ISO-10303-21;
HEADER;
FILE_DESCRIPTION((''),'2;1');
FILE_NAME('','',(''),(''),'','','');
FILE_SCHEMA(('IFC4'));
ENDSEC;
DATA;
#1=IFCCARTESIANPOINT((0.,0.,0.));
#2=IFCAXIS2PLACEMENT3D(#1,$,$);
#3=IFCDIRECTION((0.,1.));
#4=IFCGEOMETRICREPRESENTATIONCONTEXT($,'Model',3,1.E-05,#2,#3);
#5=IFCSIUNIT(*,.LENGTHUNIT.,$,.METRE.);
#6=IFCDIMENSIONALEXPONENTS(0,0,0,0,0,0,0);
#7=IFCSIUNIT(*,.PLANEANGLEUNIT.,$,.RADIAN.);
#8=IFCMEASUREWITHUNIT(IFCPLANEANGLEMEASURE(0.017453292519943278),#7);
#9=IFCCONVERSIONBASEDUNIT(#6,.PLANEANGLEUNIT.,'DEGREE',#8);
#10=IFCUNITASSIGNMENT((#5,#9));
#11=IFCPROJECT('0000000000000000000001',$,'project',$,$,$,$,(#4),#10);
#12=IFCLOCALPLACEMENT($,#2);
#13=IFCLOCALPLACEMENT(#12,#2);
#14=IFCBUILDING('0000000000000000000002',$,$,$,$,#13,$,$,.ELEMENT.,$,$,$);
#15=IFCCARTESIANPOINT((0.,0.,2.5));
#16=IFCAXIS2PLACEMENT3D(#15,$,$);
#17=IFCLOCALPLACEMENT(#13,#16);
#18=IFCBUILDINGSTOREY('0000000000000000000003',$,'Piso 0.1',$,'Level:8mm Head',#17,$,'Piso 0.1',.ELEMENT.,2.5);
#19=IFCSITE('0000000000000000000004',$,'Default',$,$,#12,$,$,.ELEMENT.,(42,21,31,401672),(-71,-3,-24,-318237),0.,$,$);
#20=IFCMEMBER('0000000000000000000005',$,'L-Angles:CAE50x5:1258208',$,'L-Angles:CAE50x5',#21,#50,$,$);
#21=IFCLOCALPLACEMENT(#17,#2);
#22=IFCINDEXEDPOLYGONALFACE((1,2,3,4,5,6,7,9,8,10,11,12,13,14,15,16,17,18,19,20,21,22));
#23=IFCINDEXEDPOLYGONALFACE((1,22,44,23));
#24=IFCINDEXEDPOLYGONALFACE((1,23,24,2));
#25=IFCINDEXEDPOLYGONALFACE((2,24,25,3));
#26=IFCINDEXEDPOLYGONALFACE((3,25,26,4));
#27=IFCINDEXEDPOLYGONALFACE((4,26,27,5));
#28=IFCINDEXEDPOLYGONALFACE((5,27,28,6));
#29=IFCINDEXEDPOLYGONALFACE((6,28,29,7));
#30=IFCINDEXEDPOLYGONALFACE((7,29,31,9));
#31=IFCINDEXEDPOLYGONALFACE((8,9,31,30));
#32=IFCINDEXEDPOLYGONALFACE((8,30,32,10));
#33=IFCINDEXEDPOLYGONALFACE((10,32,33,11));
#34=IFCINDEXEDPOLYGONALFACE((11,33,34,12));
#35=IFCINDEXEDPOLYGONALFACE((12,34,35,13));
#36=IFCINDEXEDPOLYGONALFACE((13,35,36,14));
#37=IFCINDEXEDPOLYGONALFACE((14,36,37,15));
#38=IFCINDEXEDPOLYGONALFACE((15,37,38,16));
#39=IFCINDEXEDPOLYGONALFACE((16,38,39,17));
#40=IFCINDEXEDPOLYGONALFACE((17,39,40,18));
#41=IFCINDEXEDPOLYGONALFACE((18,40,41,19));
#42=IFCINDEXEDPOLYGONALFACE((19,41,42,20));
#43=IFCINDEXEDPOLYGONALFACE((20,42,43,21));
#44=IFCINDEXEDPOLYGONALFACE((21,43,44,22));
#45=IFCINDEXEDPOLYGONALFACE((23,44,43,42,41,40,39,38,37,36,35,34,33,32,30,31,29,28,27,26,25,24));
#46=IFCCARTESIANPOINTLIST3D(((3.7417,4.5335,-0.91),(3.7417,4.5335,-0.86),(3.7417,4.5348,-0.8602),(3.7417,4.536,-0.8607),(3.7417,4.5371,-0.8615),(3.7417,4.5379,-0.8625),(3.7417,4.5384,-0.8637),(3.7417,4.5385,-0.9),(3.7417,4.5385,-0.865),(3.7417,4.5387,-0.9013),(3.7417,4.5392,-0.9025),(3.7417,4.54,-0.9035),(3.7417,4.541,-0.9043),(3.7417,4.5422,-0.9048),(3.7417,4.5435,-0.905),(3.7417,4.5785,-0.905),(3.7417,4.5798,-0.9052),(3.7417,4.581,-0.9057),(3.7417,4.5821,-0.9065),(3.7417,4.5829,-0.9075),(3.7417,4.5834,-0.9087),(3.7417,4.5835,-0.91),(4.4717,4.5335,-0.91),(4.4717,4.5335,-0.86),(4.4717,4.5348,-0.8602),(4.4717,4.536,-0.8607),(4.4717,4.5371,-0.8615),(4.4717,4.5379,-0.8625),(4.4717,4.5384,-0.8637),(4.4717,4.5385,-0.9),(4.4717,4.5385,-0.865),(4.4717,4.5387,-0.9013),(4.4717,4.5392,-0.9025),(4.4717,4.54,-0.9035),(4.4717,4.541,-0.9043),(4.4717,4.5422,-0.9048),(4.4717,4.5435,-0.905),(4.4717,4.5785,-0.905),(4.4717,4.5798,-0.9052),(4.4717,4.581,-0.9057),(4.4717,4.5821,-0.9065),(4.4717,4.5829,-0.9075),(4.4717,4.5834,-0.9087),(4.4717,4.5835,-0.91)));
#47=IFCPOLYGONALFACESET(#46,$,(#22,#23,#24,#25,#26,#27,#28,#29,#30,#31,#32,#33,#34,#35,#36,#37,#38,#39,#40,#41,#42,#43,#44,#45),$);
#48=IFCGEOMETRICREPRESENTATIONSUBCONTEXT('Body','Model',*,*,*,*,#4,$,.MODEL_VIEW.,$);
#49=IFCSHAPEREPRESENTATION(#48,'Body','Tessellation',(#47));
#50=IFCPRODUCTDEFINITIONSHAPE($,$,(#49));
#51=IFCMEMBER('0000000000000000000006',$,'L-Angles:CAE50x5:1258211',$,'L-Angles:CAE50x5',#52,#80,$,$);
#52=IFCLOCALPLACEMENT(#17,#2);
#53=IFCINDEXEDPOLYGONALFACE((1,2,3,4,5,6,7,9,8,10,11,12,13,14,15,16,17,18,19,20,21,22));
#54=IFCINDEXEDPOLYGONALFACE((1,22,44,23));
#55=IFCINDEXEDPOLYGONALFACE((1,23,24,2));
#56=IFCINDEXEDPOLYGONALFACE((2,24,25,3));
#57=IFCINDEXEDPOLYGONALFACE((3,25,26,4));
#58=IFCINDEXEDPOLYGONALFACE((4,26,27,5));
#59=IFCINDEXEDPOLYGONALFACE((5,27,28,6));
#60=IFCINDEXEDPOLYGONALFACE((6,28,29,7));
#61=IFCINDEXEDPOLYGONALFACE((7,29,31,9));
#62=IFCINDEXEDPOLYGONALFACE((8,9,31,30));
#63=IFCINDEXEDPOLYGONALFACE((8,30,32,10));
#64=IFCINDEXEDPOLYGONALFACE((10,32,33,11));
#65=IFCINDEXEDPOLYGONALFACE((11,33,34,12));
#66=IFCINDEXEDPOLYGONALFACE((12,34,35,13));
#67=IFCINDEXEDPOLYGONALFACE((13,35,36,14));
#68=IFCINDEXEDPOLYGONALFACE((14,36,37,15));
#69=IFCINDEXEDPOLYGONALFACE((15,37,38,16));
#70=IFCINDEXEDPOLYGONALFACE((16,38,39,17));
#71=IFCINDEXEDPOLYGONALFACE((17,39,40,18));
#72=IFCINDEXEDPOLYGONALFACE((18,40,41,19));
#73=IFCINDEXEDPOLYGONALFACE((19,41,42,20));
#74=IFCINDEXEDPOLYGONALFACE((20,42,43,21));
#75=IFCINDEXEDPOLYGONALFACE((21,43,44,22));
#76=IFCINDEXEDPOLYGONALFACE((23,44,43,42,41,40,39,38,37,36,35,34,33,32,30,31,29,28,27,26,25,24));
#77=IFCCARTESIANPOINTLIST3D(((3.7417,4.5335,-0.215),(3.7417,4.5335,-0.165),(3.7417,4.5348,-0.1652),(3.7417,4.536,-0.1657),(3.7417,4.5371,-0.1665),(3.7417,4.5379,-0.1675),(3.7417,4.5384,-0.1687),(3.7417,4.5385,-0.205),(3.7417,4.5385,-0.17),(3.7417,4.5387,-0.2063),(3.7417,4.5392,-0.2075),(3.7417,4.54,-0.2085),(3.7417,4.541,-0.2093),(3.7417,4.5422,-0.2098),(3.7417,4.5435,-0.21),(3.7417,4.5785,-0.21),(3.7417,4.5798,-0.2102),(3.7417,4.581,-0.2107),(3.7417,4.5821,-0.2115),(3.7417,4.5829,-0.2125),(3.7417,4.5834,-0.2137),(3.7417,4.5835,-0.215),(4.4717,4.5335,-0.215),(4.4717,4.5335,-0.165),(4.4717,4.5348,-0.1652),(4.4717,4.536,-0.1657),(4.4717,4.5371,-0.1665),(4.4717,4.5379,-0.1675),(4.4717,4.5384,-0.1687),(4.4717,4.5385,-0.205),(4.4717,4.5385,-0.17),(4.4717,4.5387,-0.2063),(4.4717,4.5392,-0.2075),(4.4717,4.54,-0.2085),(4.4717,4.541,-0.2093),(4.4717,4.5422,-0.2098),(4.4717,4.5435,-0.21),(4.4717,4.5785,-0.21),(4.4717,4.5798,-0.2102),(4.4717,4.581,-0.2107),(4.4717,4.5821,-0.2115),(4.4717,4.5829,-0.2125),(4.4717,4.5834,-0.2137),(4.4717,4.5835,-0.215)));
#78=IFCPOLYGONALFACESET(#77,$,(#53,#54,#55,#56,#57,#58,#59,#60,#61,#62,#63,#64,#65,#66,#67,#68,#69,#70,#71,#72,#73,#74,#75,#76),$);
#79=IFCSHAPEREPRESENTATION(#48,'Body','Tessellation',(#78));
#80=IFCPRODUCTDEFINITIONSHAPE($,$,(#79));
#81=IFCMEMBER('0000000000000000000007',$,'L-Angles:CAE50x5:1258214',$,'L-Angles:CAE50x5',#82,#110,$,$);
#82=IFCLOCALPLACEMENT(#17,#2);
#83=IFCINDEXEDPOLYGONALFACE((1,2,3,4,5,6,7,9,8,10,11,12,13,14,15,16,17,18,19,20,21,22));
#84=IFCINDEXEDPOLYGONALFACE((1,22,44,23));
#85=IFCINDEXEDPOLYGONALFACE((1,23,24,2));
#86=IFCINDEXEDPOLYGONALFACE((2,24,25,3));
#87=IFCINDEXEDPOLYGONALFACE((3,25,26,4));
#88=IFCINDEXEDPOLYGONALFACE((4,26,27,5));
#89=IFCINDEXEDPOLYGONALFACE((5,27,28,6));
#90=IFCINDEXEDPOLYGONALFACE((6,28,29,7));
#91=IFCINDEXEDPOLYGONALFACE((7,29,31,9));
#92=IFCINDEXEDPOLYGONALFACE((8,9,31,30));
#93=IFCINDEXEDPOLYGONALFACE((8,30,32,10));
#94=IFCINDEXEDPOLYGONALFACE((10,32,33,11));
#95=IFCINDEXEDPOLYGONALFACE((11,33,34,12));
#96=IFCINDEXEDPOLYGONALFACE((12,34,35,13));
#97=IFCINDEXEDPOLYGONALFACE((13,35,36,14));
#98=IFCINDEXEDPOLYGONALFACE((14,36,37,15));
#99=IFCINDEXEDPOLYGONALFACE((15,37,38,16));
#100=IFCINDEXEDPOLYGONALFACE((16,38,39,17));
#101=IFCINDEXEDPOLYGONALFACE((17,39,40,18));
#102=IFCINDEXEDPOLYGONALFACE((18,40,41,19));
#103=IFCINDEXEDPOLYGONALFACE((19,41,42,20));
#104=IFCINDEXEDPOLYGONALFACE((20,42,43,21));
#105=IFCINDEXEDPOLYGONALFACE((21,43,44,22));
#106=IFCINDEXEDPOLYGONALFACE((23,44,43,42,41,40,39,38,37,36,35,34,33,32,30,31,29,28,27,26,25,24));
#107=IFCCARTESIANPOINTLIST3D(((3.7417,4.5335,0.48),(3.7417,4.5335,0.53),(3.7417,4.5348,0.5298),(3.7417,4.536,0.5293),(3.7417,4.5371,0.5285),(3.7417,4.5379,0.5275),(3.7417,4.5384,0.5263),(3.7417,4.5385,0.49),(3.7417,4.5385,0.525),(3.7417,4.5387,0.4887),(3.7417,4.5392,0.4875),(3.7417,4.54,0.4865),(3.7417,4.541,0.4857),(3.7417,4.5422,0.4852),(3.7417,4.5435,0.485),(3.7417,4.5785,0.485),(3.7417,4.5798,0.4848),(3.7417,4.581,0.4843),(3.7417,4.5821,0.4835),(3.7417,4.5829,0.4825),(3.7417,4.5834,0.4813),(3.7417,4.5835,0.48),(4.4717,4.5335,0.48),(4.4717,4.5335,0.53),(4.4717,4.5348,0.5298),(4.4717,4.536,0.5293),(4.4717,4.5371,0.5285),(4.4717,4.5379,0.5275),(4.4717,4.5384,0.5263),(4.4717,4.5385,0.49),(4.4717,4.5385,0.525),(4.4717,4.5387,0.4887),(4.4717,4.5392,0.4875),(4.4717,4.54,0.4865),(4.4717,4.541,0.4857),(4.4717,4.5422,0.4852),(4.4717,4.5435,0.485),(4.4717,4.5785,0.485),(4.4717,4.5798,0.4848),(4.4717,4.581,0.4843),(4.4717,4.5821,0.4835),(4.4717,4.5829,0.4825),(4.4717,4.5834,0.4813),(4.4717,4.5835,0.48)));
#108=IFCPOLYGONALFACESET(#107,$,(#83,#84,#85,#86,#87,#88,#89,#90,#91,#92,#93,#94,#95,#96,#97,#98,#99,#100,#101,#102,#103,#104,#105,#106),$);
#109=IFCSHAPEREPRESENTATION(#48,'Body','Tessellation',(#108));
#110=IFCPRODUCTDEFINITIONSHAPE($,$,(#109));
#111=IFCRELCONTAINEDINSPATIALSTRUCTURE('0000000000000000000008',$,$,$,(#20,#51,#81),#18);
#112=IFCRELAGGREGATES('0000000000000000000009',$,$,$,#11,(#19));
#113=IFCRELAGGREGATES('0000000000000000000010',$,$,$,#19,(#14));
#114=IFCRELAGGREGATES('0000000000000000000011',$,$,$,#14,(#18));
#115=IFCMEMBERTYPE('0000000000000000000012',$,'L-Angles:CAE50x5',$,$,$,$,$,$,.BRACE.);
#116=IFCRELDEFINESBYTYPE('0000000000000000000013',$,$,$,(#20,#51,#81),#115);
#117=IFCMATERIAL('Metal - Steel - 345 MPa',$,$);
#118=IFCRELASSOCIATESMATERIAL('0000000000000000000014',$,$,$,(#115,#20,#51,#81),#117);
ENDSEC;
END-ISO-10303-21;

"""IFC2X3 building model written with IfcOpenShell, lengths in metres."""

from ifc_helpers import new_model, entity, si_unit, converted_unit, direction, frame, frame_2d, origin, place, context, subcontext, project, spatial, polyline, circle_curve, parameter, trimmed, segment, composite_curve, outline, extrude, source, transform, mapped, material, type_object, type_shapes, element, save


model = new_model("IFC2X3")

# Units and contexts
model_context = context("Model", 3, precision=1e-05, world=origin(), true_north=direction((0.0, 1.0)))
body_context = subcontext(model_context, "Body", "Model", "MODEL_VIEW")
ifc_project = project(units=[si_unit("LENGTHUNIT", "METRE"), converted_unit("PLANEANGLEUNIT", "DEGREE", entity("IfcPlaneAngleMeasure", 0.017453292519943278), si_unit("PLANEANGLEUNIT", "RADIAN"), dimensions=[0, 0, 0, 0, 0, 0, 0])], contexts=[model_context])

# Site, building, storey
site_placement = place(None, origin())
site = spatial("IfcSite", under=ifc_project, at=site_placement, Name="Default", CompositionType="ELEMENT", RefLatitude=(42, 21, 31, 401672), RefLongitude=(-71, -3, -24, -318237), RefElevation=0.0)
building_placement = place(site_placement, origin())
building = spatial("IfcBuilding", under=site, at=building_placement, CompositionType="ELEMENT")
storey_placement = place(building_placement, frame((0.0, 0.0, 2.5)))
storey = spatial("IfcBuildingStorey", under=building, at=storey_placement, Name="Piso 0.1", ObjectType="Level:8mm Head", LongName="Piso 0.1", CompositionType="ELEMENT", Elevation=2.5)

# Members
ifc_material = material(Name="Metal - Steel - 345 MPa")
member_type_1 = type_object("IfcMemberType", Name="L-Angles:CAE50x5", PredefinedType="BRACE", material=ifc_material)
shared_shape_1 = source(origin(), body_context, "Body", "SweptSolid", [
    extrude(outline(composite_curve([segment(polyline([(-0.0164, -0.0164), (0.0336, -0.0164)]), True, "CONTINUOUS"), segment(trimmed(circle_curve(frame_2d((0.0286, -0.0164), x_axis=(1.0, 0.0)), 0.005), [parameter(0.0)], [parameter(90.0)], True, "PARAMETER"), True, "CONTINUOUS"), segment(polyline([(0.0286, -0.0114), (-0.0064, -0.0114)]), True, "CONTINUOUS"), segment(trimmed(circle_curve(frame_2d((-0.0064, -0.0064), x_axis=(1.0, 0.0)), 0.005), [parameter(180.0)], [parameter(270.0)], True, "PARAMETER"), False, "CONTINUOUS"), segment(polyline([(-0.0114, -0.0064), (-0.0114, 0.0286)]), True, "CONTINUOUS"), segment(trimmed(circle_curve(frame_2d((-0.0164, 0.0286), x_axis=(1.0, 0.0)), 0.005), [parameter(0.0)], [parameter(90.0)], True, "PARAMETER"), True, "CONTINUOUS"), segment(polyline([(-0.0164, 0.0336), (-0.0164, -0.0164)]), True, "CONTINUOUS")], self_intersect=False)), frame((-0.365, -0.0024, -0.0024), z_axis=(1.0, 0.0, 0.0), x_axis=(0.0, -1.0, 0.0)), (0.0, 0.0, 1.0), 0.73),
])
type_shapes(member_type_1, [shared_shape_1])
for number, where, z_axis, x_axis, name in (
    (1, (4.1067, 4.5475, -0.896), (0.0, -1.0, 0.0), (-1.0, 0.0, 0.0), "L-Angles:CAE50x5:1258208"),
    (2, (4.1067, 4.5475, -0.201), (0.0, -1.0, 0.0), (-1.0, 0.0, 0.0), "L-Angles:CAE50x5:1258211"),
    (3, (4.1067, 4.5475, 0.494), (0.0, -1.0, 0.0), (-1.0, 0.0, 0.0), "L-Angles:CAE50x5:1258214"),
):
    element("IfcMember", number, at=place(storey_placement, frame(where, z_axis=z_axis, x_axis=x_axis)), inside=storey, type_object=member_type_1, material=ifc_material, Name=name, ObjectType="L-Angles:CAE50x5", context=body_context, shape_type="MappedRepresentation", body=[
        mapped(shared_shape_1, transform((0.0, 0.0, 0.0), scale=1.0)),
    ])

save(model, "model.ifc")
